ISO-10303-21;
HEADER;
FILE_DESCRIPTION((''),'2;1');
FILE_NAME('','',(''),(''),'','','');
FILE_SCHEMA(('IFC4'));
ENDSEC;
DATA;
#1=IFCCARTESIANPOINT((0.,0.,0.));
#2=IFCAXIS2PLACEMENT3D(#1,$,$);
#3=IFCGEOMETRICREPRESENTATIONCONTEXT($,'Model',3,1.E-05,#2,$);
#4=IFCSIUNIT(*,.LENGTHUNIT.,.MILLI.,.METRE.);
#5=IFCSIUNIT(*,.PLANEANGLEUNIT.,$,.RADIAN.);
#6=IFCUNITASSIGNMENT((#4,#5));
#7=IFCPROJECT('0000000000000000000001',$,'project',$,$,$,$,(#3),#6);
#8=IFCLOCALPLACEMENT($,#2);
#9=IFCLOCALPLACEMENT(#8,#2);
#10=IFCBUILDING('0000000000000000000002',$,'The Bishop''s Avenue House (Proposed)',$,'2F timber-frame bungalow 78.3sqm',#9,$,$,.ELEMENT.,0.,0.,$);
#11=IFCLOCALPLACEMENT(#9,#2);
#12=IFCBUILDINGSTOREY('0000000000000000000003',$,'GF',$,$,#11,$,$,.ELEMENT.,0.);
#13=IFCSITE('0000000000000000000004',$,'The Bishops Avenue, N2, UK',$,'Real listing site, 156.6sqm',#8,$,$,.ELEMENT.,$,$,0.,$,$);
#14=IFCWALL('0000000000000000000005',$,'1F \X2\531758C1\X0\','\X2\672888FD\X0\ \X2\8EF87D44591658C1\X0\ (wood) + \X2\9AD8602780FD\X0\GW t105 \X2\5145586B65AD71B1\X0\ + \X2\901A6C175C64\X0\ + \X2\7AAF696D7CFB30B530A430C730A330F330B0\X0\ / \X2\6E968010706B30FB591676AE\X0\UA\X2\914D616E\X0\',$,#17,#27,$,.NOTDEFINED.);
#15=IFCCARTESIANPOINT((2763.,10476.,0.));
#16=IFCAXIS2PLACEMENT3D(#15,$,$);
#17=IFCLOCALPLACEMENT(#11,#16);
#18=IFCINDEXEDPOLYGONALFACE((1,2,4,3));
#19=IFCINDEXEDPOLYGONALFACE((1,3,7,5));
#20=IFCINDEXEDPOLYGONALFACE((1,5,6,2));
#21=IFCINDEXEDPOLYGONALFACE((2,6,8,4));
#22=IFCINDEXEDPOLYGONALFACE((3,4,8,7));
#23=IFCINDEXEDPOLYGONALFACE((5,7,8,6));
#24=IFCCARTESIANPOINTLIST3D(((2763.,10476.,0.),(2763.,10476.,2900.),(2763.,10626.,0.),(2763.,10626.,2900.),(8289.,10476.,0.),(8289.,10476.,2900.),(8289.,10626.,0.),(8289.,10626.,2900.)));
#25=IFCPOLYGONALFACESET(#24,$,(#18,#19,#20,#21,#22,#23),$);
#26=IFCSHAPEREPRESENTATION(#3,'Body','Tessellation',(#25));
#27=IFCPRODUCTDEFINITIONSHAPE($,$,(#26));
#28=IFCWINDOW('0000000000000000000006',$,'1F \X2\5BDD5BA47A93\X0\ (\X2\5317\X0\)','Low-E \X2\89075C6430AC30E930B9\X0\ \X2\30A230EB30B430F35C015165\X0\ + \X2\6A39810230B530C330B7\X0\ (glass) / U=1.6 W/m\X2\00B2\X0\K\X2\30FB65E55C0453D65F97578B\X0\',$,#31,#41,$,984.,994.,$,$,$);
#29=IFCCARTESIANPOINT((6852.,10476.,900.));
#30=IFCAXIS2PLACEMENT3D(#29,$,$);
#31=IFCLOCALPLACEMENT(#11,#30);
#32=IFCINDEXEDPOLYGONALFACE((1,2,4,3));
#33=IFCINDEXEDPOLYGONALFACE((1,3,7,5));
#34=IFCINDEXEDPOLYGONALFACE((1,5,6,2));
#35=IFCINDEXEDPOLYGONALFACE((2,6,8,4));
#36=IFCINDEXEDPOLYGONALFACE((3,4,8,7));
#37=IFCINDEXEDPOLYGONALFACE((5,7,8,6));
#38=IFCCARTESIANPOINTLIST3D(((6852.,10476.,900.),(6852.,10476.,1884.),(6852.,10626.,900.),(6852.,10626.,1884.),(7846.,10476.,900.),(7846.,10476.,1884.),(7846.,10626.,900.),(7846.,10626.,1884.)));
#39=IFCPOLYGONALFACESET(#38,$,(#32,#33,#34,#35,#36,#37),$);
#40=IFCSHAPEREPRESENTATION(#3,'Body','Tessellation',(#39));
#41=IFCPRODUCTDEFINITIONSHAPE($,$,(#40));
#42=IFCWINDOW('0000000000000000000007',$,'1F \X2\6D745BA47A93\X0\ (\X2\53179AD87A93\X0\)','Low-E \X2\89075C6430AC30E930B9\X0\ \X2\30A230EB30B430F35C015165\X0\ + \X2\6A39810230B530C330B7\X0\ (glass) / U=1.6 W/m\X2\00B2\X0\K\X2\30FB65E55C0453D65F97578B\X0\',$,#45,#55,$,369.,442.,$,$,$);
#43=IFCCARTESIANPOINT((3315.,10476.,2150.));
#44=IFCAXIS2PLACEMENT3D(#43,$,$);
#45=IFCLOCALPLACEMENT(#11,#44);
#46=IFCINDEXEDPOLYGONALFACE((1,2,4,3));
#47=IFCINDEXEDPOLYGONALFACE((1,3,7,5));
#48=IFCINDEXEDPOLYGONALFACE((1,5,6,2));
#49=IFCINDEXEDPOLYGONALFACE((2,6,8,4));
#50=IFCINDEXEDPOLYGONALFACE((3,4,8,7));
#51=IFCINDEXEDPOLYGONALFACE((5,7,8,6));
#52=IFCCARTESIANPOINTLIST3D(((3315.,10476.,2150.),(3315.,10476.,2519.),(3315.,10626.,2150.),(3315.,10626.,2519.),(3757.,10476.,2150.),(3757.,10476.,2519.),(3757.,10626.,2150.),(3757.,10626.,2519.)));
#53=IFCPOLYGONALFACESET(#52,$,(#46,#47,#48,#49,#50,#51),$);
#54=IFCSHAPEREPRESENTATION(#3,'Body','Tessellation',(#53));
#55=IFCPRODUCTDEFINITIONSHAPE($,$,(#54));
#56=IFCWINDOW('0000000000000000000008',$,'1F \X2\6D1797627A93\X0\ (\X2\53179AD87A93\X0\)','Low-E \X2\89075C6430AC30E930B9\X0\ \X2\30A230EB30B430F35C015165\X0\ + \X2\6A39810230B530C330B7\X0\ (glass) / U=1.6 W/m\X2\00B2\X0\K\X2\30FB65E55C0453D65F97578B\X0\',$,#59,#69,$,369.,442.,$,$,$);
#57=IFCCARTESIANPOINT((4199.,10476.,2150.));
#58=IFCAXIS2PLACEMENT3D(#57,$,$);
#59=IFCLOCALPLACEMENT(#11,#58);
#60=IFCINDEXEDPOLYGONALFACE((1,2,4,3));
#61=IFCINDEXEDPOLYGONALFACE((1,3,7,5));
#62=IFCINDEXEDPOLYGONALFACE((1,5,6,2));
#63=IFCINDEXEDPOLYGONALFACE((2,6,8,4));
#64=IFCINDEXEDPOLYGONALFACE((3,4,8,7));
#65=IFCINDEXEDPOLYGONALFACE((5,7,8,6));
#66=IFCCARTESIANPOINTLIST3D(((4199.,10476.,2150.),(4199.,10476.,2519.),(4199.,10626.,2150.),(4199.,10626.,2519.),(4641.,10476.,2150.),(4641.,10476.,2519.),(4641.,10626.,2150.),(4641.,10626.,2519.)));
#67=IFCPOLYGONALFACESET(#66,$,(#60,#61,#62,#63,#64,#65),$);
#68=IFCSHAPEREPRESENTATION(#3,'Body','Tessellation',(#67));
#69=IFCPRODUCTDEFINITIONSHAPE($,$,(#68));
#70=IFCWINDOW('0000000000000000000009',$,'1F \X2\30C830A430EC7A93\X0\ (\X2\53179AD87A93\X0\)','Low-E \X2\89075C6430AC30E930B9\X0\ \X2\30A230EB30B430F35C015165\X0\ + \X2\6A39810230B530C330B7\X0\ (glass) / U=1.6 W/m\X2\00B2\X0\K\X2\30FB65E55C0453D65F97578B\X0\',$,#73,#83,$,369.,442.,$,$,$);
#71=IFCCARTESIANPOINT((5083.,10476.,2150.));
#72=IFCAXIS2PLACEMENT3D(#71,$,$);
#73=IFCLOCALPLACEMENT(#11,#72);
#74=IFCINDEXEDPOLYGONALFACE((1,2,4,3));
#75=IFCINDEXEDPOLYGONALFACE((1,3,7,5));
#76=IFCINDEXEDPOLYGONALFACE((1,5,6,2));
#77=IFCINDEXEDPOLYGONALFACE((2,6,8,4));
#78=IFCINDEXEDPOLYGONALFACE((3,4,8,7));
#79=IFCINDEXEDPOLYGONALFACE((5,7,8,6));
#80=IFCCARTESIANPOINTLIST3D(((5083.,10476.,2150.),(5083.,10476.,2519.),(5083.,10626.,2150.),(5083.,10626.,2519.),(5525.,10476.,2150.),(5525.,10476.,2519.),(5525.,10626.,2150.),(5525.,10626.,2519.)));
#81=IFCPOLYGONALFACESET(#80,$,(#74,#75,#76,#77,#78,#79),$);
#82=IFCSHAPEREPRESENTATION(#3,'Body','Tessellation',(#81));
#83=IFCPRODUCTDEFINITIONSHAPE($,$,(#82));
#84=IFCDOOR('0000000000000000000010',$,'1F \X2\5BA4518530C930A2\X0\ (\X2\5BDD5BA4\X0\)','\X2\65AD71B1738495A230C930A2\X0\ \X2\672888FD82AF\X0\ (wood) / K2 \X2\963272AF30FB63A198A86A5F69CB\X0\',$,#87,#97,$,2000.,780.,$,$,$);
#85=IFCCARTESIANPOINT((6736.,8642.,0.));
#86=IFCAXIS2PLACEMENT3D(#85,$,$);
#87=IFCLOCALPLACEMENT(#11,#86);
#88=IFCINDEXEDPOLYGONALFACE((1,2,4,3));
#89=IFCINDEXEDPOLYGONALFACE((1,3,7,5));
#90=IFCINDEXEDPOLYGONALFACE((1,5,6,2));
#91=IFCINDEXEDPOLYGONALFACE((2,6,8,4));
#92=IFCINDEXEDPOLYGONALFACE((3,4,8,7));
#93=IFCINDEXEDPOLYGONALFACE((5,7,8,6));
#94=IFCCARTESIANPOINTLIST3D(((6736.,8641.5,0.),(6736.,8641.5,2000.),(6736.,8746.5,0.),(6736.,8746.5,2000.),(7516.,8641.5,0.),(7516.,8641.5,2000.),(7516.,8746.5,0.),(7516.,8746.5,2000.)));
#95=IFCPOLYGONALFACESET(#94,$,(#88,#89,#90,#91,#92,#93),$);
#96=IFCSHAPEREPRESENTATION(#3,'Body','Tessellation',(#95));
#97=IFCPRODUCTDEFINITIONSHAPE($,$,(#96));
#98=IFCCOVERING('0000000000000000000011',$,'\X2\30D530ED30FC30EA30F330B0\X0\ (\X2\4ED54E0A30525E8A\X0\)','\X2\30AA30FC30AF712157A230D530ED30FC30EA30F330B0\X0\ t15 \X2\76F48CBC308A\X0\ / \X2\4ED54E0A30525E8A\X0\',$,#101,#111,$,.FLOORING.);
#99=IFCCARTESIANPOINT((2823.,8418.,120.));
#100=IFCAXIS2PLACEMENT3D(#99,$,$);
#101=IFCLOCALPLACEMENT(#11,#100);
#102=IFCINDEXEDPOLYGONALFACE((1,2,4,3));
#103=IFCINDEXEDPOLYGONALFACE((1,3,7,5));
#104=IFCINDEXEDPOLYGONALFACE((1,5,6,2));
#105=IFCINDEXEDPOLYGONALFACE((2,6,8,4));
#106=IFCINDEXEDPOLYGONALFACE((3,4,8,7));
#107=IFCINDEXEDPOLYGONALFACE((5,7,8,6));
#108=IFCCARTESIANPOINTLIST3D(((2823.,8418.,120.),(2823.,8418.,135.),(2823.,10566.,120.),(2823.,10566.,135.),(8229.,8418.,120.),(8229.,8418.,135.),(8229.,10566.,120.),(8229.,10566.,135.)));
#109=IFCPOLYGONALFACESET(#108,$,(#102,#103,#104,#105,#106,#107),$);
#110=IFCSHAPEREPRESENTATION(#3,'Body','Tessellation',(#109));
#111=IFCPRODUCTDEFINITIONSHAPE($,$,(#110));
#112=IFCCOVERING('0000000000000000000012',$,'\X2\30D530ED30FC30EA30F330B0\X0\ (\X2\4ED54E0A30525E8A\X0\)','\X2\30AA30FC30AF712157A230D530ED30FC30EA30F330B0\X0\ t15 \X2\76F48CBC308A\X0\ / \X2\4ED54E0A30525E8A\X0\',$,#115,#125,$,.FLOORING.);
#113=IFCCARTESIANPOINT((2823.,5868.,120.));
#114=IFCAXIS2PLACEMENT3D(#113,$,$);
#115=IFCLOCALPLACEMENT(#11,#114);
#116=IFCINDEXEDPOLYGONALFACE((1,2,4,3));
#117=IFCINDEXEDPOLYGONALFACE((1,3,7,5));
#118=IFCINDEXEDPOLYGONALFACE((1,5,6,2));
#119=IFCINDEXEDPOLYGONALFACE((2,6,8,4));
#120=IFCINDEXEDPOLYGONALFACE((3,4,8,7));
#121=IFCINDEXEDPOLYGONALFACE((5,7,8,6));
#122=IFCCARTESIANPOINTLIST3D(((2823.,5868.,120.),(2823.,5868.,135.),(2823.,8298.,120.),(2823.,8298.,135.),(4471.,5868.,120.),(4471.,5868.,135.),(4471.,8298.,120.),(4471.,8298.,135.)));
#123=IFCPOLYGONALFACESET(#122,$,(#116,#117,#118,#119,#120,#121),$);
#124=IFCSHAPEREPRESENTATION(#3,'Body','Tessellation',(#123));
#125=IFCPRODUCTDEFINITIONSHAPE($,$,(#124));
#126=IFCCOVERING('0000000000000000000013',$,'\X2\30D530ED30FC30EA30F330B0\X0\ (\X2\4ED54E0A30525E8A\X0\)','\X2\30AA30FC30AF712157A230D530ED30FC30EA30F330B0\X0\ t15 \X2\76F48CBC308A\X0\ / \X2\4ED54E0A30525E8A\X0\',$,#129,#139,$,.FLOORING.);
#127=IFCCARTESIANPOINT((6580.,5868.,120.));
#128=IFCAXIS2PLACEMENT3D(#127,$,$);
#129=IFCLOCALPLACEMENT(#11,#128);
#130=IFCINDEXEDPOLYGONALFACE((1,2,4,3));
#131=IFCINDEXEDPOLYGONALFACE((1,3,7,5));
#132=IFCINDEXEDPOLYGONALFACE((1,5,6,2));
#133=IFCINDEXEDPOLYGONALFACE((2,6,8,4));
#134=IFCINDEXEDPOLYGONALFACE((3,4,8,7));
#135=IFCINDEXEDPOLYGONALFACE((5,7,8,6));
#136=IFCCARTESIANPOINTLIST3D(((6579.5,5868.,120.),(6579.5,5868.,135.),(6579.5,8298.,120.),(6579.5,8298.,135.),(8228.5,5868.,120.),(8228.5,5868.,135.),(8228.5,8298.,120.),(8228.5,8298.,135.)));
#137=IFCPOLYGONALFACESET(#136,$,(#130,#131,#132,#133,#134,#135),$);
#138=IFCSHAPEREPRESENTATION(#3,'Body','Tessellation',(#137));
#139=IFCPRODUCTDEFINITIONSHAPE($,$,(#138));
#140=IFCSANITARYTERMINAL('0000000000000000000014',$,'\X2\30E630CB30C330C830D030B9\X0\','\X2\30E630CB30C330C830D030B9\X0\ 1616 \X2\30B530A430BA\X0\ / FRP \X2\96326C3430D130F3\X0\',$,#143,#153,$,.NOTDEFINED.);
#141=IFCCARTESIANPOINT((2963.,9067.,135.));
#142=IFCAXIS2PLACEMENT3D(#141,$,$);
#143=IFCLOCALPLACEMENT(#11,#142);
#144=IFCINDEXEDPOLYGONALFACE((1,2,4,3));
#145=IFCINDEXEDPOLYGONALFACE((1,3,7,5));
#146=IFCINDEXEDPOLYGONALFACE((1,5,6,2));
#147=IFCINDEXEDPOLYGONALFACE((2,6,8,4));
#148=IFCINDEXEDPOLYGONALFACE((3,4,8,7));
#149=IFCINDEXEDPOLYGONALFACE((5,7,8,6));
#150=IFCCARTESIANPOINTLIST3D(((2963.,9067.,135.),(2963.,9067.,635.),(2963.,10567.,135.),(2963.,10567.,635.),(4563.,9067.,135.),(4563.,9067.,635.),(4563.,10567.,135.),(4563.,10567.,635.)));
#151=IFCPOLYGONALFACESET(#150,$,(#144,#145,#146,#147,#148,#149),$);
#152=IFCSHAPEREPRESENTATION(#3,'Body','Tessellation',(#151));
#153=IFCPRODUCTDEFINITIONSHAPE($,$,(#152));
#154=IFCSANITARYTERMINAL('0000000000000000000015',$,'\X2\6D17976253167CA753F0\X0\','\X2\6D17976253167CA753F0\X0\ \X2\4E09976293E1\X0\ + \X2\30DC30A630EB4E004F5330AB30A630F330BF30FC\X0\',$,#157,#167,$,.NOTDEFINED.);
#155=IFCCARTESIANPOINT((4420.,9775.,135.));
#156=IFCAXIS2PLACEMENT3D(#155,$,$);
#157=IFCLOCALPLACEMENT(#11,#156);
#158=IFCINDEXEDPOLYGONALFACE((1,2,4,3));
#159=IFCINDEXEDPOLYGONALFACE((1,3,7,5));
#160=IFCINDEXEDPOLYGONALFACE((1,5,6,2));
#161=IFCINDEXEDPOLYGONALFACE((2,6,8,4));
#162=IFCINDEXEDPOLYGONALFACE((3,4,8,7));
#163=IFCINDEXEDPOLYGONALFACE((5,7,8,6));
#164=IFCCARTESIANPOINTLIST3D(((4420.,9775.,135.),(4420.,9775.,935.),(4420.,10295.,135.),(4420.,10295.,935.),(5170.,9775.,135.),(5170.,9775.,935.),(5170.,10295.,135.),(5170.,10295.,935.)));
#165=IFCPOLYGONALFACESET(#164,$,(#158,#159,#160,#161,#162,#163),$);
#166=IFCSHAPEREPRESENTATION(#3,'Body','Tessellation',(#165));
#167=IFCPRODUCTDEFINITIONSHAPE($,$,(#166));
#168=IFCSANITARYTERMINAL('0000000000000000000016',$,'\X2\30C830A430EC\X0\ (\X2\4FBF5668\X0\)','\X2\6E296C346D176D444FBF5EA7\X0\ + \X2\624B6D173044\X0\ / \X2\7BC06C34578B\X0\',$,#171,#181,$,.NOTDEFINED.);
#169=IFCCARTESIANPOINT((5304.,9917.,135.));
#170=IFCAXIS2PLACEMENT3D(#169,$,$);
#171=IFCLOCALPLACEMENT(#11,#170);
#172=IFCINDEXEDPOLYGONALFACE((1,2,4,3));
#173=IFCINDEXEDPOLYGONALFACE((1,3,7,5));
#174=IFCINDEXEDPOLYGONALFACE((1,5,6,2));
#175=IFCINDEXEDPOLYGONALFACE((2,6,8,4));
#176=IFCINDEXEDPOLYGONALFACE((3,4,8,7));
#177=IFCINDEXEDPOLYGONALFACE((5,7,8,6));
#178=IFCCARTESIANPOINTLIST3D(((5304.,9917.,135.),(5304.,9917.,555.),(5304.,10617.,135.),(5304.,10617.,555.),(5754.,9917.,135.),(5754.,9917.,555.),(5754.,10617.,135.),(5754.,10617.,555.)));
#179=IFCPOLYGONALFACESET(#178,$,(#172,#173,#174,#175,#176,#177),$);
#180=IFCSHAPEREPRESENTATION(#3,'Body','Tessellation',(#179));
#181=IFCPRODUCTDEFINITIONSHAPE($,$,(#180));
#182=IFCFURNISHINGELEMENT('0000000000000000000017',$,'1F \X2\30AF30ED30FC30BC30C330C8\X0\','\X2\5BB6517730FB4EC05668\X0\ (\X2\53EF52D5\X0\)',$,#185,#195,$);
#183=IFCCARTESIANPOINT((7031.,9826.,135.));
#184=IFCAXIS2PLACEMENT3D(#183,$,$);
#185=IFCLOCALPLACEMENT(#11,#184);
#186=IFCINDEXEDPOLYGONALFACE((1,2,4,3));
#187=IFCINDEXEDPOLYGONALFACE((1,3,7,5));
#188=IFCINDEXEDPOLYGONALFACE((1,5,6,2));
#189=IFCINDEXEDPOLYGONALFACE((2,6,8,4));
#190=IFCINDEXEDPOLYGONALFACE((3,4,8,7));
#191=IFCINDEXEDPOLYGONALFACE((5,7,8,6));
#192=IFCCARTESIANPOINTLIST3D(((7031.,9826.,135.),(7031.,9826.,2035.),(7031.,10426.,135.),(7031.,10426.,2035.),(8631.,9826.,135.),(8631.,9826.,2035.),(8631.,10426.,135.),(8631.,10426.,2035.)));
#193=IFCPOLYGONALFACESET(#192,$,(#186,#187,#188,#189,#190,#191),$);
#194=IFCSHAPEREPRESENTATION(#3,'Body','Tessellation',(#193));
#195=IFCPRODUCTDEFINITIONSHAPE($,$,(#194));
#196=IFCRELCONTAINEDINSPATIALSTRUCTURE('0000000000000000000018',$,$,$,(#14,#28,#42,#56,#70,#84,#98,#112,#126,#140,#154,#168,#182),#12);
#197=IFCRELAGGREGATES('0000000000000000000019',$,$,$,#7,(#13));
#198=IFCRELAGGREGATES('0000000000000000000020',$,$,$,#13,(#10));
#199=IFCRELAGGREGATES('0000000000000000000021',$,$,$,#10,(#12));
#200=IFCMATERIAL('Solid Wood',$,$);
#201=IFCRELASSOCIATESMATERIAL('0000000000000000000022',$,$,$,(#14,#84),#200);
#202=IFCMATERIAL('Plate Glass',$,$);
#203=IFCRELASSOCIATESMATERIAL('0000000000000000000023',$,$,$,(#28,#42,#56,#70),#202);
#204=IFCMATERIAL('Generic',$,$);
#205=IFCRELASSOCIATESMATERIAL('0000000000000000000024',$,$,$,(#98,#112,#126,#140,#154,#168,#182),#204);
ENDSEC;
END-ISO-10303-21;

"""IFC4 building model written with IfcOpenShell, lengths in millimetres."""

from ifc_helpers import new_model, si_unit, frame, frame_2d, origin, place, context, project, spatial, rectangle, extrude, material, element, fill, save


model = new_model("IFC4")

# Units and contexts
model_context = context("Model", 3, precision=1e-05, world=origin())
ifc_project = project(units=[si_unit("LENGTHUNIT", "METRE", prefix="MILLI"), si_unit("PLANEANGLEUNIT", "RADIAN")], contexts=[model_context])

# Site, building, storey
site_placement = place(None, origin())
site = spatial("IfcSite", under=ifc_project, at=site_placement, Name="The Bishops Avenue, N2, UK", ObjectType="Real listing site, 156.6sqm", CompositionType="ELEMENT", RefElevation=0.0)
building_placement = place(site_placement, origin())
building = spatial("IfcBuilding", under=site, at=building_placement, Name="The Bishop's Avenue House (Proposed)", ObjectType="2F timber-frame bungalow 78.3sqm", CompositionType="ELEMENT", ElevationOfRefHeight=0.0, ElevationOfTerrain=0.0)
storey_placement = place(building_placement, origin())
storey = spatial("IfcBuildingStorey", under=building, at=storey_placement, Name="GF", CompositionType="ELEMENT", Elevation=0.0)

# Shared definitions
ifc_material_1 = material(Name="Solid Wood")

# Wall, openings, windows
wall_1_placement = place(storey_placement, frame((2763.0, 10476.0, 0.0)))
wall_1 = element("IfcWall", 1, at=wall_1_placement, inside=storey, material=ifc_material_1, Name="1F 北壁", Description="木製 軸組外壁 (wood) + 高性能GW t105 充填断熱 + 通気層 + 窯業系サイディング / 準耐火・外皮UA配慮", PredefinedType="NOTDEFINED", context=model_context, shape_type="SweptSolid", body=[
    extrude(rectangle(XDim=5526.0, YDim=150.0, at=frame_2d((2763.0, 75.0))), frame((2763.0, 10476.0, 0.0)), (0.0, 0.0, 1.0), 2900.0),
])
opening_1_placement = place(storey_placement, frame((6852.0, 10476.0, 900.0)))
opening_1 = element("IfcOpeningElement", 2, at=opening_1_placement, cuts=wall_1, PredefinedType="NOTDEFINED", context=model_context, shape_type="SweptSolid", body=[
    extrude(rectangle(XDim=994.0, YDim=150.0, at=frame_2d((497.0, 75.0))), frame((6852.0, 10476.0, 900.0)), (0.0, 0.0, 1.0), 984.0),
])
opening_2_placement = place(storey_placement, frame((3315.0, 10476.0, 2150.0)))
opening_2 = element("IfcOpeningElement", 3, at=opening_2_placement, cuts=wall_1, PredefinedType="NOTDEFINED", context=model_context, shape_type="SweptSolid", body=[
    extrude(rectangle(XDim=442.0, YDim=150.0, at=frame_2d((221.0, 75.0))), frame((3315.0, 10476.0, 2150.0)), (0.0, 0.0, 1.0), 369.0),
])
opening_3_placement = place(storey_placement, frame((4199.0, 10476.0, 2150.0)))
opening_3 = element("IfcOpeningElement", 4, at=opening_3_placement, cuts=wall_1, PredefinedType="NOTDEFINED", context=model_context, shape_type="SweptSolid", body=[
    extrude(rectangle(XDim=442.0, YDim=150.0, at=frame_2d((221.0, 75.0))), frame((4199.0, 10476.0, 2150.0)), (0.0, 0.0, 1.0), 369.0),
])
opening_4_placement = place(storey_placement, frame((5083.0, 10476.0, 2150.0)))
opening_4 = element("IfcOpeningElement", 5, at=opening_4_placement, cuts=wall_1, PredefinedType="NOTDEFINED", context=model_context, shape_type="SweptSolid", body=[
    extrude(rectangle(XDim=442.0, YDim=150.0, at=frame_2d((221.0, 75.0))), frame((5083.0, 10476.0, 2150.0)), (0.0, 0.0, 1.0), 369.0),
])
ifc_material_2 = material(Name="Plate Glass")
window_1_placement = place(storey_placement, frame((6852.0, 10476.0, 900.0)))
window_1 = element("IfcWindow", 6, at=window_1_placement, inside=storey, material=ifc_material_2, Name="1F 寝室窓 (北)", Description="Low-E 複層ガラス アルゴン封入 + 樹脂サッシ (glass) / U=1.6 W/m²K・日射取得型", OverallHeight=984.0, OverallWidth=994.0, context=model_context, shape_type="SweptSolid", body=[
    extrude(rectangle(XDim=994.0, YDim=150.0, at=frame_2d((497.0, 75.0))), frame((6852.0, 10476.0, 900.0)), (0.0, 0.0, 1.0), 984.0),
])
fill(opening_1, window_1)
window_2_placement = place(storey_placement, frame((3315.0, 10476.0, 2150.0)))
window_2 = element("IfcWindow", 7, at=window_2_placement, inside=storey, material=ifc_material_2, Name="1F 浴室窓 (北高窓)", Description="Low-E 複層ガラス アルゴン封入 + 樹脂サッシ (glass) / U=1.6 W/m²K・日射取得型", OverallHeight=369.0, OverallWidth=442.0, context=model_context, shape_type="SweptSolid", body=[
    extrude(rectangle(XDim=442.0, YDim=150.0, at=frame_2d((221.0, 75.0))), frame((3315.0, 10476.0, 2150.0)), (0.0, 0.0, 1.0), 369.0),
])
fill(opening_2, window_2)
window_3_placement = place(storey_placement, frame((4199.0, 10476.0, 2150.0)))
window_3 = element("IfcWindow", 8, at=window_3_placement, inside=storey, material=ifc_material_2, Name="1F 洗面窓 (北高窓)", Description="Low-E 複層ガラス アルゴン封入 + 樹脂サッシ (glass) / U=1.6 W/m²K・日射取得型", OverallHeight=369.0, OverallWidth=442.0, context=model_context, shape_type="SweptSolid", body=[
    extrude(rectangle(XDim=442.0, YDim=150.0, at=frame_2d((221.0, 75.0))), frame((4199.0, 10476.0, 2150.0)), (0.0, 0.0, 1.0), 369.0),
])
fill(opening_3, window_3)
window_4_placement = place(storey_placement, frame((5083.0, 10476.0, 2150.0)))
window_4 = element("IfcWindow", 9, at=window_4_placement, inside=storey, material=ifc_material_2, Name="1F トイレ窓 (北高窓)", Description="Low-E 複層ガラス アルゴン封入 + 樹脂サッシ (glass) / U=1.6 W/m²K・日射取得型", OverallHeight=369.0, OverallWidth=442.0, context=model_context, shape_type="SweptSolid", body=[
    extrude(rectangle(XDim=442.0, YDim=150.0, at=frame_2d((221.0, 75.0))), frame((5083.0, 10476.0, 2150.0)), (0.0, 0.0, 1.0), 369.0),
])
fill(opening_4, window_4)

# Door
door_1_placement = place(storey_placement, frame((6736.0, 8642.0, 0.0)))
element("IfcDoor", 10, at=door_1_placement, inside=storey, material=ifc_material_1, Name="1F 室内ドア (寝室)", Description="断熱玄関ドア 木製芯 (wood) / K2 防犯・採風機構", OverallHeight=2000.0, OverallWidth=780.0, context=model_context, shape_type="SweptSolid", body=[
    extrude(rectangle(XDim=780.0, YDim=105.0, at=frame_2d((390.0, 52.0))), frame((6736.0, 8642.0, 0.0)), (0.0, 0.0, 1.0), 2000.0),
])

# Coverings
ifc_material_3 = material(Name="Generic")
covering_1_placement = place(storey_placement, frame((2823.0, 8418.0, 120.0)))
element("IfcCovering", 11, at=covering_1_placement, inside=storey, material=ifc_material_3, Name="フローリング (仕上げ床)", Description="オーク無垢フローリング t15 直貼り / 仕上げ床", PredefinedType="FLOORING", context=model_context, shape_type="SweptSolid", body=[
    extrude(rectangle(XDim=5406.0, YDim=2148.0, at=frame_2d((2703.0, 1074.0))), frame((2823.0, 8418.0, 120.0)), (0.0, 0.0, 1.0), 15.0),
])
covering_2_placement = place(storey_placement, frame((2823.0, 5868.0, 120.0)))
element("IfcCovering", 12, at=covering_2_placement, inside=storey, material=ifc_material_3, Name="フローリング (仕上げ床)", Description="オーク無垢フローリング t15 直貼り / 仕上げ床", PredefinedType="FLOORING", context=model_context, shape_type="SweptSolid", body=[
    extrude(rectangle(XDim=1648.0, YDim=2430.0, at=frame_2d((824.0, 1215.0))), frame((2823.0, 5868.0, 120.0)), (0.0, 0.0, 1.0), 15.0),
])
covering_3_placement = place(storey_placement, frame((6580.0, 5868.0, 120.0)))
element("IfcCovering", 13, at=covering_3_placement, inside=storey, material=ifc_material_3, Name="フローリング (仕上げ床)", Description="オーク無垢フローリング t15 直貼り / 仕上げ床", PredefinedType="FLOORING", context=model_context, shape_type="SweptSolid", body=[
    extrude(rectangle(XDim=1649.0, YDim=2430.0, at=frame_2d((824.0, 1215.0))), frame((6580.0, 5868.0, 120.0)), (0.0, 0.0, 1.0), 15.0),
])

# Sanitary terminals
sanitary_terminal_1_placement = place(storey_placement, frame((2963.0, 9067.0, 135.0)))
element("IfcSanitaryTerminal", 14, at=sanitary_terminal_1_placement, inside=storey, material=ifc_material_3, Name="ユニットバス", Description="ユニットバス 1616 サイズ / FRP 防水パン", PredefinedType="NOTDEFINED", context=model_context, shape_type="SweptSolid", body=[
    extrude(rectangle(XDim=1600.0, YDim=1500.0, at=frame_2d((800.0, 750.0))), frame((2963.0, 9067.0, 135.0)), (0.0, 0.0, 1.0), 500.0),
])
sanitary_terminal_2_placement = place(storey_placement, frame((4420.0, 9775.0, 135.0)))
element("IfcSanitaryTerminal", 15, at=sanitary_terminal_2_placement, inside=storey, material=ifc_material_3, Name="洗面化粧台", Description="洗面化粧台 三面鏡 + ボウル一体カウンター", PredefinedType="NOTDEFINED", context=model_context, shape_type="SweptSolid", body=[
    extrude(rectangle(XDim=750.0, YDim=520.0, at=frame_2d((375.0, 260.0))), frame((4420.0, 9775.0, 135.0)), (0.0, 0.0, 1.0), 800.0),
])
sanitary_terminal_3_placement = place(storey_placement, frame((5304.0, 9917.0, 135.0)))
element("IfcSanitaryTerminal", 16, at=sanitary_terminal_3_placement, inside=storey, material=ifc_material_3, Name="トイレ (便器)", Description="温水洗浄便座 + 手洗い / 節水型", PredefinedType="NOTDEFINED", context=model_context, shape_type="SweptSolid", body=[
    extrude(rectangle(XDim=450.0, YDim=700.0, at=frame_2d((225.0, 350.0))), frame((5304.0, 9917.0, 135.0)), (0.0, 0.0, 1.0), 420.0),
])

# Furnishing element
furnishing_placement = place(storey_placement, frame((7031.0, 9826.0, 135.0)))
element("IfcFurnishingElement", 17, at=furnishing_placement, inside=storey, material=ifc_material_3, Name="1F クローゼット", Description="家具・什器 (可動)", context=model_context, shape_type="SweptSolid", body=[
    extrude(rectangle(XDim=1600.0, YDim=600.0, at=frame_2d((800.0, 300.0))), frame((7031.0, 9826.0, 135.0)), (0.0, 0.0, 1.0), 1900.0),
])

save(model, "model.ifc")
